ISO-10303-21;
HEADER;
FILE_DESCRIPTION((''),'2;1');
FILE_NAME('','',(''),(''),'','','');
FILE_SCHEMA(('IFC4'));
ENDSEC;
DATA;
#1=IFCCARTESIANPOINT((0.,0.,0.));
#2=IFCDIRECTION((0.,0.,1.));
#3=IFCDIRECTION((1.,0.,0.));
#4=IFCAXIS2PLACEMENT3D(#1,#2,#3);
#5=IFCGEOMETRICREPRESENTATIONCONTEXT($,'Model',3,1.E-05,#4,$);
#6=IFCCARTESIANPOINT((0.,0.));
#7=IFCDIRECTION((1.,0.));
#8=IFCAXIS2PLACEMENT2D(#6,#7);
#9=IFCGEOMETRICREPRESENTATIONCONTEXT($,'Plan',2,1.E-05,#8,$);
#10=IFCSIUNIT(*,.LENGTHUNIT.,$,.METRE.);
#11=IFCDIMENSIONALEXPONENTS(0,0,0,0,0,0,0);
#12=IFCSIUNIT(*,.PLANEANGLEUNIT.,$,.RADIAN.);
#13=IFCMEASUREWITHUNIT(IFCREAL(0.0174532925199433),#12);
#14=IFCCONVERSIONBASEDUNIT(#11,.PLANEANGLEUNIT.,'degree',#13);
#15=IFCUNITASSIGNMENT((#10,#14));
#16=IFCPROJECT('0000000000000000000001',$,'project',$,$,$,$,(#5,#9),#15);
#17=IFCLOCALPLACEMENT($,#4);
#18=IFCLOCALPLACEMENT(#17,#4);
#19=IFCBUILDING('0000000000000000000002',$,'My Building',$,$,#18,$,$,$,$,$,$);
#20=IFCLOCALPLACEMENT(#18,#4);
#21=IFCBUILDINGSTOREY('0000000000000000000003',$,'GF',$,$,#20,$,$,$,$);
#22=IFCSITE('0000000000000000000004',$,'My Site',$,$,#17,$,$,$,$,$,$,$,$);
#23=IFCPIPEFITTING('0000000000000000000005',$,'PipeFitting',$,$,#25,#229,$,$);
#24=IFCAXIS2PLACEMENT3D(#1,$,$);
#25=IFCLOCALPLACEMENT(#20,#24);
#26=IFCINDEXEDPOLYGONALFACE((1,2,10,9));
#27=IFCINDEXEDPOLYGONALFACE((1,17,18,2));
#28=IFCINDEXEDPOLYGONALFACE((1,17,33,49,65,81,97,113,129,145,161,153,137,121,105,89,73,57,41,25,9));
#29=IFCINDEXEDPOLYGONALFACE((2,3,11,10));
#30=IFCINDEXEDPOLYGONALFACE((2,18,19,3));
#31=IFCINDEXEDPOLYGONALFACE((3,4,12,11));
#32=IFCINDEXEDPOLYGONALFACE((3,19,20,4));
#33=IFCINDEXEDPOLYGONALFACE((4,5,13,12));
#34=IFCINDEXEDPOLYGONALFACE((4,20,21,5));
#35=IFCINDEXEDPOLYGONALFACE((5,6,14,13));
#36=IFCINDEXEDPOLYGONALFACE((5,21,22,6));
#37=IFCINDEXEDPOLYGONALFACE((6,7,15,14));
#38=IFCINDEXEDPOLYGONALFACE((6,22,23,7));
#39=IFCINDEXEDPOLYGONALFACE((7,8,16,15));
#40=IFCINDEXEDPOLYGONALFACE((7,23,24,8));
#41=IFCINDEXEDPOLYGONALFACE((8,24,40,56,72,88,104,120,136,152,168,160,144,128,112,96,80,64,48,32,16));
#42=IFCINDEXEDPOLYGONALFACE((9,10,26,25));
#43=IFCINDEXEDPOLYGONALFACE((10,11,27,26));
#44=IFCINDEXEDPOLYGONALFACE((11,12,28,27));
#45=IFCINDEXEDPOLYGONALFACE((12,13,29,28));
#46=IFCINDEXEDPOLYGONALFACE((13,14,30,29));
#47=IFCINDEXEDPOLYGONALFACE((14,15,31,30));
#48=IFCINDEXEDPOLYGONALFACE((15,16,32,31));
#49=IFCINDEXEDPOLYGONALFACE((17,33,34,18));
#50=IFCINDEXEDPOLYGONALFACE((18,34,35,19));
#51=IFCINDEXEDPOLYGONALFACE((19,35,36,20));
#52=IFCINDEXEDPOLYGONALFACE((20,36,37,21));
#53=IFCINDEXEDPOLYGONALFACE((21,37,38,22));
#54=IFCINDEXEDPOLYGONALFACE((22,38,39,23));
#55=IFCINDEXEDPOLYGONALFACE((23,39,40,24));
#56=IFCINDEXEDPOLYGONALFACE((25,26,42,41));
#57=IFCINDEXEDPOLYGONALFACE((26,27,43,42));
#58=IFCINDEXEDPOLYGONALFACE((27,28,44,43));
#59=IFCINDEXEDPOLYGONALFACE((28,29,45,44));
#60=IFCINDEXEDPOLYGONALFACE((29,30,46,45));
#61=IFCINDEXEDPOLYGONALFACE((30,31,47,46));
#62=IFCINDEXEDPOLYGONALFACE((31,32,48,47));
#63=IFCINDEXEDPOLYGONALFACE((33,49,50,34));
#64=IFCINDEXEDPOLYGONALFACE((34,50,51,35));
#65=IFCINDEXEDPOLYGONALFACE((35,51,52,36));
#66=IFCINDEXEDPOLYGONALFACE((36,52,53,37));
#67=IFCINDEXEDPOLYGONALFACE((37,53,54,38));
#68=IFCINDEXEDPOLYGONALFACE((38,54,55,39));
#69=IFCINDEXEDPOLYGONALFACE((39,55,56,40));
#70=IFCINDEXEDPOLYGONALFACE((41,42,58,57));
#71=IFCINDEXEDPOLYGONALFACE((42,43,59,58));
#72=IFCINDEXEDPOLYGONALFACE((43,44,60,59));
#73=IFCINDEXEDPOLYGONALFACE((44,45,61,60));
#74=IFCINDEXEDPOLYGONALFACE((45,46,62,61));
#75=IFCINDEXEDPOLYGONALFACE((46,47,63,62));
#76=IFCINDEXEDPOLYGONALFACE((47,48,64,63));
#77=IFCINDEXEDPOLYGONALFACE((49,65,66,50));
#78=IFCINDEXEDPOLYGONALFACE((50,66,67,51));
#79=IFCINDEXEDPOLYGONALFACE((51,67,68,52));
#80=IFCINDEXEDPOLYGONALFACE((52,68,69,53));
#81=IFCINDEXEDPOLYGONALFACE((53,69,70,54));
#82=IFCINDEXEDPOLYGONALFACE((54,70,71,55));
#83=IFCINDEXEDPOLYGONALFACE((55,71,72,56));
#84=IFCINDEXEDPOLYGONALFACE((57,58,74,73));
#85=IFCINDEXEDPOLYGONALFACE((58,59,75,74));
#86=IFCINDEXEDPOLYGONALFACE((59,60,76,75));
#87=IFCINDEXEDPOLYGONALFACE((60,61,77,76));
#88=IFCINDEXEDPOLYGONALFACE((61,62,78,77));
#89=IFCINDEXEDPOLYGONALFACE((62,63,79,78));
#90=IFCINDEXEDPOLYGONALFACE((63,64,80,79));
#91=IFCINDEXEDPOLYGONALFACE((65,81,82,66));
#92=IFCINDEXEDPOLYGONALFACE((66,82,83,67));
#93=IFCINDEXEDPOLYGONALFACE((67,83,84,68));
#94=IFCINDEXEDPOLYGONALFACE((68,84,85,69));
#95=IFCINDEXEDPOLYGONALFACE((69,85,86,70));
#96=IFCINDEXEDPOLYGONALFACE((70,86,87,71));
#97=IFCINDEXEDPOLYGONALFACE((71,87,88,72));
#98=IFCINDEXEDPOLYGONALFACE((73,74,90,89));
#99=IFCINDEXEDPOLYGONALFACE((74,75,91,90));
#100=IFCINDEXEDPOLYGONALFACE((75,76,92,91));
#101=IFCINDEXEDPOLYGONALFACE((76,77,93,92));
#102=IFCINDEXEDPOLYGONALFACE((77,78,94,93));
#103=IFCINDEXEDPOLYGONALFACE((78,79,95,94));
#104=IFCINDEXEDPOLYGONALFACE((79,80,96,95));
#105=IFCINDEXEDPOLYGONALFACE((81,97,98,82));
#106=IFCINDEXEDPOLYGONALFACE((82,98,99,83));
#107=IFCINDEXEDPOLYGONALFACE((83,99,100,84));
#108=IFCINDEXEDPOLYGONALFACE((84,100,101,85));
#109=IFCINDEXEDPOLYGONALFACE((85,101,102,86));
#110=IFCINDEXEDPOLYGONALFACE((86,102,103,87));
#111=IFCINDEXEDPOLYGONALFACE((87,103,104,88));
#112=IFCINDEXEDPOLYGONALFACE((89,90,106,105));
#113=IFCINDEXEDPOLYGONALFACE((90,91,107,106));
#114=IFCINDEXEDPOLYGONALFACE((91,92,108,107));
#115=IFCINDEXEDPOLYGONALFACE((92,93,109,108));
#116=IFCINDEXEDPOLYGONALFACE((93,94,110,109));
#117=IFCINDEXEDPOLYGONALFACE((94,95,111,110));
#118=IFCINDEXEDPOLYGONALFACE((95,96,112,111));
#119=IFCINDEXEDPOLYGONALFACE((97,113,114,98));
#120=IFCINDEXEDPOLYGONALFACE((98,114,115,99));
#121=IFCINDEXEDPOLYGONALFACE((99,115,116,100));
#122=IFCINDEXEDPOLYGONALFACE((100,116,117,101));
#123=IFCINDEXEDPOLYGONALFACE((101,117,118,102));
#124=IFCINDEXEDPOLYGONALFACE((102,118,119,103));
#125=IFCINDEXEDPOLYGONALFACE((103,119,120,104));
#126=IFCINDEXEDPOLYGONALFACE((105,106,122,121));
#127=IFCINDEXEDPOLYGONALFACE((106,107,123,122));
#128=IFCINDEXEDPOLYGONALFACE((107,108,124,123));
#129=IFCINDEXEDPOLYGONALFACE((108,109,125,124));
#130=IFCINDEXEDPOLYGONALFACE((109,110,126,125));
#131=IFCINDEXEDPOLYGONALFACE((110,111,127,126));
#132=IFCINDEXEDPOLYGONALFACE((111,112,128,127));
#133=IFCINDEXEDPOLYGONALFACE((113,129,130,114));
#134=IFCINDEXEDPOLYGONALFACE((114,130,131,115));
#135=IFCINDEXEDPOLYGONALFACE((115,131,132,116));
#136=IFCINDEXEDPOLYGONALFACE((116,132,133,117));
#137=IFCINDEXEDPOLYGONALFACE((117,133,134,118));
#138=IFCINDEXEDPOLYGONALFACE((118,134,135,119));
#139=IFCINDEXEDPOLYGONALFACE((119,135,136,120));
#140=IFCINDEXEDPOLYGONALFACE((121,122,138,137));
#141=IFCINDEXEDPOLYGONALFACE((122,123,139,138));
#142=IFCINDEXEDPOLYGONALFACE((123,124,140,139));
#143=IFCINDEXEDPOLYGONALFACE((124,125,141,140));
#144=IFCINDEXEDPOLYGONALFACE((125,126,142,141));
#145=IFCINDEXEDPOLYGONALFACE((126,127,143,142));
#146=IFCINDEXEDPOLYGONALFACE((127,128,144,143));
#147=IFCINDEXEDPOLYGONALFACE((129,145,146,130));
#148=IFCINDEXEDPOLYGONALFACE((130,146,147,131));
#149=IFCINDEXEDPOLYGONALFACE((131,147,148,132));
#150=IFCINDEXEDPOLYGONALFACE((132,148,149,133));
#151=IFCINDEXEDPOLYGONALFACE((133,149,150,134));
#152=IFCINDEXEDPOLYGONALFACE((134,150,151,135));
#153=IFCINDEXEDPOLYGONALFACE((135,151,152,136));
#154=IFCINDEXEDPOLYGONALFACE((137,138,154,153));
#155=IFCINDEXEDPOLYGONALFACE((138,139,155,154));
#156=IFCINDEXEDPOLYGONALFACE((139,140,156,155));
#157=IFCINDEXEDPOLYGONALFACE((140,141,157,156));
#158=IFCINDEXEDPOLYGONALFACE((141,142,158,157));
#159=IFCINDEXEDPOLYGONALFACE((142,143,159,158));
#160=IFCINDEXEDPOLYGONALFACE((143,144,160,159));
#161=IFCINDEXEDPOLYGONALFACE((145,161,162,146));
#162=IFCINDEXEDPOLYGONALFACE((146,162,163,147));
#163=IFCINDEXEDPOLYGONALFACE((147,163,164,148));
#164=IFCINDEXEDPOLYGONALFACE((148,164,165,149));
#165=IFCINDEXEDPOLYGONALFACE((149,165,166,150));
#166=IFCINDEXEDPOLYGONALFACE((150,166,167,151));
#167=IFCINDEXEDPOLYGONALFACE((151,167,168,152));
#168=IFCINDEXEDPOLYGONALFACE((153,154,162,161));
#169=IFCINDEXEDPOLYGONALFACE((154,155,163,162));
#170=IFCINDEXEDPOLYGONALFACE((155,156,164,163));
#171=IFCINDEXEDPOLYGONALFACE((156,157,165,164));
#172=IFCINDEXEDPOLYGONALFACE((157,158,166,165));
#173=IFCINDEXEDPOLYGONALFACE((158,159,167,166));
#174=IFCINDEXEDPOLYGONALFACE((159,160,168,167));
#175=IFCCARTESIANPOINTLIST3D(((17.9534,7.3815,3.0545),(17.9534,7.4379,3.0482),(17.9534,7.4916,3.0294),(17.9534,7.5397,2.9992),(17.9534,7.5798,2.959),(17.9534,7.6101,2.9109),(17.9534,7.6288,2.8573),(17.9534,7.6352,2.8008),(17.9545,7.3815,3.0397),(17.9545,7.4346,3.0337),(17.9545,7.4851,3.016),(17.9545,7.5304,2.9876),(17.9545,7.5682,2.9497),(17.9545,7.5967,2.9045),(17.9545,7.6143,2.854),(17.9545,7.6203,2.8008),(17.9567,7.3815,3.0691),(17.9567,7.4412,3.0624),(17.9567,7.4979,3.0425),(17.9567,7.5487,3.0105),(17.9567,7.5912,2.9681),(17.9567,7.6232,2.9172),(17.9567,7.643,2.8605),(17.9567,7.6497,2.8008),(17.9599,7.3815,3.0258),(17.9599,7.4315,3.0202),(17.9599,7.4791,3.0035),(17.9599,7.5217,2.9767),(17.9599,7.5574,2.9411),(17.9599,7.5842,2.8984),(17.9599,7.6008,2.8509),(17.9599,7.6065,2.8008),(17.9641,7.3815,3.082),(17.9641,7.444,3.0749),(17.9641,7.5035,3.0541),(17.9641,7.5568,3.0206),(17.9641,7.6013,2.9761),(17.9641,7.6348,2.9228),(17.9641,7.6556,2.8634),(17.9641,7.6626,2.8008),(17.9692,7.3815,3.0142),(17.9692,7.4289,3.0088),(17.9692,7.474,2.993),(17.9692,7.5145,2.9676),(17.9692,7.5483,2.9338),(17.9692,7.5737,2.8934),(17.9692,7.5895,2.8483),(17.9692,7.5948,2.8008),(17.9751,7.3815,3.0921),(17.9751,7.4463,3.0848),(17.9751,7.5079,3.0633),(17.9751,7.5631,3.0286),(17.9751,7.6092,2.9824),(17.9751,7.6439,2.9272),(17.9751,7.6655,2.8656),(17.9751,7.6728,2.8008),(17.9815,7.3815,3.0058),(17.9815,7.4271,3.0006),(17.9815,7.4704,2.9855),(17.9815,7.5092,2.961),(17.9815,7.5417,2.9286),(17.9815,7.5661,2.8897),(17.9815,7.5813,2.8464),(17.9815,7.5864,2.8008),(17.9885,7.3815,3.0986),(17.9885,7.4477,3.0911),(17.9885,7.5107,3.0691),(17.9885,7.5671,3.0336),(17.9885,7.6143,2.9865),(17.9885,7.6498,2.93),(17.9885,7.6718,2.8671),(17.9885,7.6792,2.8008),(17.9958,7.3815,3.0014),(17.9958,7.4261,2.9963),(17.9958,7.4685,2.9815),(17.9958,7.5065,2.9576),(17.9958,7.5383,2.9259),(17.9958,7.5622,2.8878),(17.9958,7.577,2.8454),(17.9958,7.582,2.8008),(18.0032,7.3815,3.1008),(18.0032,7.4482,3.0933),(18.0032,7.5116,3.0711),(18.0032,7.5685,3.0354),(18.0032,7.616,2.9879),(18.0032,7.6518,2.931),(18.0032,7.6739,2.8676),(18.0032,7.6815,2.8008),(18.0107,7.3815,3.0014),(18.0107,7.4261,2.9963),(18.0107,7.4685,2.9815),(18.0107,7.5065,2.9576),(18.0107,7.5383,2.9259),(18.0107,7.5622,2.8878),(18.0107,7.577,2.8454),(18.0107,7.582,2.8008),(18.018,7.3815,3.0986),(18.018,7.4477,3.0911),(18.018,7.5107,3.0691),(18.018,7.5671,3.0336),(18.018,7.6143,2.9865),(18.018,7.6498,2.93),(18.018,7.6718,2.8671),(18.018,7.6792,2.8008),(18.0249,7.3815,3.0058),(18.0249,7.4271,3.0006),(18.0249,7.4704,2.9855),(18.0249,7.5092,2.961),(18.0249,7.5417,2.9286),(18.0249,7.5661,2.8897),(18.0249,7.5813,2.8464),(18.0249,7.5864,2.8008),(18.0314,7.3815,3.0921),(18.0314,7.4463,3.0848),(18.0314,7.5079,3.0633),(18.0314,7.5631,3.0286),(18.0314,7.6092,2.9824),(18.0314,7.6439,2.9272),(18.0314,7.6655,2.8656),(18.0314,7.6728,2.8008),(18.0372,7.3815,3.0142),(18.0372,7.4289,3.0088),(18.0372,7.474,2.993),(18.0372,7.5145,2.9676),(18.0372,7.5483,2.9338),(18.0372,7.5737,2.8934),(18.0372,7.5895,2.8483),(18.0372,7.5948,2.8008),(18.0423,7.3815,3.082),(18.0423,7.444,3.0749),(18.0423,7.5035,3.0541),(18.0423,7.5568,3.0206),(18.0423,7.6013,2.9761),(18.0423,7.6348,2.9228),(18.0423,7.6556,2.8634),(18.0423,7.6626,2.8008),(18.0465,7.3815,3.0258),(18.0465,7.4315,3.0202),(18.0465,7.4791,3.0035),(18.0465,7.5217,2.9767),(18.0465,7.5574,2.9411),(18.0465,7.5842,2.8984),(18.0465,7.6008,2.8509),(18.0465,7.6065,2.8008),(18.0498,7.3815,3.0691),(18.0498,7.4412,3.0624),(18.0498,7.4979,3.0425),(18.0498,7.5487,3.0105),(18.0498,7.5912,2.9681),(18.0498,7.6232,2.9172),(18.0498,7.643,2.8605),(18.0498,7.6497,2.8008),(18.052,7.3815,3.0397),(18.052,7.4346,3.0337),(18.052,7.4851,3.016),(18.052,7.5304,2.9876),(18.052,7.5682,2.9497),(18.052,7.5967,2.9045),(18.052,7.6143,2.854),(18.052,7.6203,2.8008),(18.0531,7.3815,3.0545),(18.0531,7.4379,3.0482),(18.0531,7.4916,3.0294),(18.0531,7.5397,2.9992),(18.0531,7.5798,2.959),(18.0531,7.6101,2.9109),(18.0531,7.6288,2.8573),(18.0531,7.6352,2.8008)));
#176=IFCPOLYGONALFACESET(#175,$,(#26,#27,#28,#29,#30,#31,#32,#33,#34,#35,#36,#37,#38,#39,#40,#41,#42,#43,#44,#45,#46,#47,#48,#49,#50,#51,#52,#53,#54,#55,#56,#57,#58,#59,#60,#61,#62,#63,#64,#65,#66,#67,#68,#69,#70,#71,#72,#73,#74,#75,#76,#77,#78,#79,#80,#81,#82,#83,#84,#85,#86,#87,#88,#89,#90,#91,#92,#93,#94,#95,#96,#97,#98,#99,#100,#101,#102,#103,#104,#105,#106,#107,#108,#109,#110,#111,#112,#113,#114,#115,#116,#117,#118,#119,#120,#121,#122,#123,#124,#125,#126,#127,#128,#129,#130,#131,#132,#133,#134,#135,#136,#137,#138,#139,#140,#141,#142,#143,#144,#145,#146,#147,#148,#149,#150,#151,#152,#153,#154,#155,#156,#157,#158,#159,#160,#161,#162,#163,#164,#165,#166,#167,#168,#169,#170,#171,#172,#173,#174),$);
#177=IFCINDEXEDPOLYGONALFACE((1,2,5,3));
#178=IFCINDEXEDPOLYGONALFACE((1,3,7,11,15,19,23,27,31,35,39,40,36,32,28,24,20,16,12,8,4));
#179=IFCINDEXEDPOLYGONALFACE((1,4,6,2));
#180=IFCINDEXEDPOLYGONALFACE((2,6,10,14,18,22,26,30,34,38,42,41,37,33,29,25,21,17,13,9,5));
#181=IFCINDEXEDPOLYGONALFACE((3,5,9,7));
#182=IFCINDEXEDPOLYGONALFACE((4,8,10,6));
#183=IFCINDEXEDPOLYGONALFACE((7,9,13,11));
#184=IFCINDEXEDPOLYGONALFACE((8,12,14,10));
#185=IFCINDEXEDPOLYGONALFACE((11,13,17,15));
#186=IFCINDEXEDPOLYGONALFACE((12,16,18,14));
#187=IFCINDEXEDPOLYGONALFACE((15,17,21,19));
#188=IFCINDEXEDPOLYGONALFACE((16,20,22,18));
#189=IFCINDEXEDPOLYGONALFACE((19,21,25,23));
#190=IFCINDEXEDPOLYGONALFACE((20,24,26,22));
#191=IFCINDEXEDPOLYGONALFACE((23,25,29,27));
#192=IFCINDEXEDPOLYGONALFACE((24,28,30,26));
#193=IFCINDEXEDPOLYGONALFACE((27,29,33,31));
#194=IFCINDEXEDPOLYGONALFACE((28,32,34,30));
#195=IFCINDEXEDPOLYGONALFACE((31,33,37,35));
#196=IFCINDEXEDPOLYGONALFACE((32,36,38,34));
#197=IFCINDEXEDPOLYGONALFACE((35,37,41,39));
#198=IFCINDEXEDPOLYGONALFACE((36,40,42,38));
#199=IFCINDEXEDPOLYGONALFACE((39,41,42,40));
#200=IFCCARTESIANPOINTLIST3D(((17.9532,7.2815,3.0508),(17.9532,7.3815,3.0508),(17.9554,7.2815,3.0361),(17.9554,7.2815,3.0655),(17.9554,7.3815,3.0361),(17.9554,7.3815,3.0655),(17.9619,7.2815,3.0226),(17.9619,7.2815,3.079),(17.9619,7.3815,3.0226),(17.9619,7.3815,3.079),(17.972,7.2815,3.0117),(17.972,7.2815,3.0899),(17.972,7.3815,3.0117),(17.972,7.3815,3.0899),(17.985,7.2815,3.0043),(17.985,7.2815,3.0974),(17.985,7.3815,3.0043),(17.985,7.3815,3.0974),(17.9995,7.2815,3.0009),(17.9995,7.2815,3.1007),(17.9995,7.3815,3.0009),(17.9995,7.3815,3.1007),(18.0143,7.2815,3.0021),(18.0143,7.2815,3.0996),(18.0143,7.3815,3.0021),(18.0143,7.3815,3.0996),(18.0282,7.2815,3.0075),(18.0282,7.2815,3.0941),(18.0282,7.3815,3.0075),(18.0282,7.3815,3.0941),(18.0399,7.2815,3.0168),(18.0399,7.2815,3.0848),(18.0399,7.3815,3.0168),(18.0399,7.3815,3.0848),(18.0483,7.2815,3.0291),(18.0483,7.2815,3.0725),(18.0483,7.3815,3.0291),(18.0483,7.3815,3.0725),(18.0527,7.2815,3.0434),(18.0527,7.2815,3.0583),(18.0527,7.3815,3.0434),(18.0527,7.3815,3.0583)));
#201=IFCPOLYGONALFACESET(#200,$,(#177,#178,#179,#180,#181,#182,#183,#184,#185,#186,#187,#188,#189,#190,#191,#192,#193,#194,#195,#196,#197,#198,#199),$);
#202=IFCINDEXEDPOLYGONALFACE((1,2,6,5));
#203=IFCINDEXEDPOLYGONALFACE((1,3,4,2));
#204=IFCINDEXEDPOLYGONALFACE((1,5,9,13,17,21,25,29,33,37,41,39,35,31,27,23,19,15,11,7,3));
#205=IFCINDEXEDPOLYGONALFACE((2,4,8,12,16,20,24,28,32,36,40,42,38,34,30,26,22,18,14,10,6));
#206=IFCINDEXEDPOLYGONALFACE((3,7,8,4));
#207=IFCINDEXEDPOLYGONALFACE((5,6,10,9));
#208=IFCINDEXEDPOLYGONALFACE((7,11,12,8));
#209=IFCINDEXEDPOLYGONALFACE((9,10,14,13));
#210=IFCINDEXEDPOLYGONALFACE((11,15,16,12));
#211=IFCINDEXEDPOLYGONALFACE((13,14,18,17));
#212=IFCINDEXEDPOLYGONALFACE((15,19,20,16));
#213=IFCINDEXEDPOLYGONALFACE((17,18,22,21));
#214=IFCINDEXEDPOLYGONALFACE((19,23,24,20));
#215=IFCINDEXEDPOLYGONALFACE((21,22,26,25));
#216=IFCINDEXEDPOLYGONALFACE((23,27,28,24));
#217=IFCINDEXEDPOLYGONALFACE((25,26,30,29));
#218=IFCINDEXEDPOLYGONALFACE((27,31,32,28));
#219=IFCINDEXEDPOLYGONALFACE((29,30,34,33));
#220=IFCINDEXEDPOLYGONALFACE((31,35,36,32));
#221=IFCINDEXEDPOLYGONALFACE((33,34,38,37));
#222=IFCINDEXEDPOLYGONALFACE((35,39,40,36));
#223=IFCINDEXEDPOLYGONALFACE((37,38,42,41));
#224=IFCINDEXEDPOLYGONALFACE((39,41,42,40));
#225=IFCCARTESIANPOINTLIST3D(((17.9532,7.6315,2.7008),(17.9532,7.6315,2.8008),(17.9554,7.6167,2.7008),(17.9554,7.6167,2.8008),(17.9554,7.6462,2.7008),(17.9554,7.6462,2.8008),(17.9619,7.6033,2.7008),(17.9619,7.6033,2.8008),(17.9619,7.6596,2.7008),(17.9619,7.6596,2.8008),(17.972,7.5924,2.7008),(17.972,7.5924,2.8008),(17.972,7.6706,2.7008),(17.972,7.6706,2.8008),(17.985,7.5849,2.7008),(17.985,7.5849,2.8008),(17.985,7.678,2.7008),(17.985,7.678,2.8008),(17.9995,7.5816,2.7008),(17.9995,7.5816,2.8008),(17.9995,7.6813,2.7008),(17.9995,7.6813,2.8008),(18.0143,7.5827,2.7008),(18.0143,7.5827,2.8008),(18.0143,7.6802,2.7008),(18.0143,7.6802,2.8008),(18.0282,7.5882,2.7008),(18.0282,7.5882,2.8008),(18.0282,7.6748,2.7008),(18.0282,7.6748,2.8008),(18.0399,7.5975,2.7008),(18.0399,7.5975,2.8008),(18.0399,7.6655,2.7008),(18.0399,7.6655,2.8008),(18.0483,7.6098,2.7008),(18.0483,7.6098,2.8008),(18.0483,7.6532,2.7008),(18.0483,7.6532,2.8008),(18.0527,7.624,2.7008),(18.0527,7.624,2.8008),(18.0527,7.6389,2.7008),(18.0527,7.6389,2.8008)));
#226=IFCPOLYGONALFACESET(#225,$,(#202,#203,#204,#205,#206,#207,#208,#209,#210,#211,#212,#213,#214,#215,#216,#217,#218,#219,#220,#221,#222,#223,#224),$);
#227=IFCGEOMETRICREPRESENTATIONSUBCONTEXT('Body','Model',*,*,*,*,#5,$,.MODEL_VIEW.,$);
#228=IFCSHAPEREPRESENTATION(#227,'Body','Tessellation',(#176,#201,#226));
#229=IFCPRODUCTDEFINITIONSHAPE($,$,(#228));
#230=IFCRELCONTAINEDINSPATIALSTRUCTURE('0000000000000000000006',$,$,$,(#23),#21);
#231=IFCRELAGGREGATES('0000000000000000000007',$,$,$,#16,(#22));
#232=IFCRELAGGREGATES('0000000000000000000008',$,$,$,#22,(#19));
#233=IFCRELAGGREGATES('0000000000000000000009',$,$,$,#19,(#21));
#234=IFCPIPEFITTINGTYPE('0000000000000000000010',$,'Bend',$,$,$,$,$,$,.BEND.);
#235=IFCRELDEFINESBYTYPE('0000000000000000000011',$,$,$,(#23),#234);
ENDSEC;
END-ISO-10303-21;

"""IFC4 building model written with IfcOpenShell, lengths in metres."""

from ifc_helpers import new_model, entity, si_unit, converted_unit, frame, origin_with_axes, origin_2d_with_axis, place, context, subcontext, project, spatial, circle, extrude, source, transform, mapped, type_object, type_shapes, element, save


model = new_model("IFC4")

# Units and contexts
model_context = context("Model", 3, precision=1e-05, world=origin_with_axes())
plan_context = context("Plan", 2, precision=1e-05, world=origin_2d_with_axis())
body_context_1 = subcontext(model_context, "Body", "Model", "MODEL_VIEW")
ifc_project = project(units=[si_unit("LENGTHUNIT", "METRE"), converted_unit("PLANEANGLEUNIT", "degree", entity("IfcReal", 0.0174532925199433), si_unit("PLANEANGLEUNIT", "RADIAN"), dimensions=[0, 0, 0, 0, 0, 0, 0])], contexts=[model_context, plan_context])

# Site, building, storey
site_placement = place(None, origin_with_axes())
site = spatial("IfcSite", under=ifc_project, at=site_placement, Name="My Site")
building_placement = place(site_placement, origin_with_axes())
building = spatial("IfcBuilding", under=site, at=building_placement, Name="My Building")
storey_placement = place(building_placement, origin_with_axes())
storey = spatial("IfcBuildingStorey", under=building, at=storey_placement, Name="GF")

# Pipe fitting
pipe_fitting_type = type_object("IfcPipeFittingType", Name="Bend", PredefinedType="BEND")
shared_shape_1 = source(origin_with_axes(), body_context_1, "Body", "SolidModel", [
    entity("IfcSweptDiskSolid", entity("IfcIndexedPolyCurve", entity("IfcCartesianPointList3D", [[0.0, 0.0, 0.1], [0.0, -0.0732, 0.2768], [0.0, -0.25, 0.35]]), [entity("IfcArcIndex", [1, 2, 3])]), 0.05),
    extrude(circle(Radius=0.05), origin_with_axes(), (0.0, 0.0, 1.0), 0.1),
    extrude(circle(Radius=0.05), frame((0.0, -0.25, 0.35), z_axis=(0.0, -1.0, 0.0), x_axis=(1.0, 0.0, 0.0)), (0.0, 0.0, 1.0), 0.1),
])
type_shapes(pipe_fitting_type, [shared_shape_1])
for number, where, z_axis, x_axis, name in (
    (1, (18.0032, 7.2815, 3.0508), (0.0, 1.0, 0.0), (-1.0, 0.0, 0.0), "PipeFitting"),
):
    element("IfcPipeFitting", number, at=place(storey_placement, frame(where, z_axis=z_axis, x_axis=x_axis)), inside=storey, type_object=pipe_fitting_type, Name=name, context=body_context_1, shape_type="MappedRepresentation", body=[
        mapped(shared_shape_1, transform((0.0, 0.0, 0.0), x_axis=(1.0, 0.0, 0.0), y_axis=(0.0, 1.0, 0.0), z_axis=(0.0, 0.0, 1.0), scale=1.0)),
    ])

save(model, "model.ifc")
